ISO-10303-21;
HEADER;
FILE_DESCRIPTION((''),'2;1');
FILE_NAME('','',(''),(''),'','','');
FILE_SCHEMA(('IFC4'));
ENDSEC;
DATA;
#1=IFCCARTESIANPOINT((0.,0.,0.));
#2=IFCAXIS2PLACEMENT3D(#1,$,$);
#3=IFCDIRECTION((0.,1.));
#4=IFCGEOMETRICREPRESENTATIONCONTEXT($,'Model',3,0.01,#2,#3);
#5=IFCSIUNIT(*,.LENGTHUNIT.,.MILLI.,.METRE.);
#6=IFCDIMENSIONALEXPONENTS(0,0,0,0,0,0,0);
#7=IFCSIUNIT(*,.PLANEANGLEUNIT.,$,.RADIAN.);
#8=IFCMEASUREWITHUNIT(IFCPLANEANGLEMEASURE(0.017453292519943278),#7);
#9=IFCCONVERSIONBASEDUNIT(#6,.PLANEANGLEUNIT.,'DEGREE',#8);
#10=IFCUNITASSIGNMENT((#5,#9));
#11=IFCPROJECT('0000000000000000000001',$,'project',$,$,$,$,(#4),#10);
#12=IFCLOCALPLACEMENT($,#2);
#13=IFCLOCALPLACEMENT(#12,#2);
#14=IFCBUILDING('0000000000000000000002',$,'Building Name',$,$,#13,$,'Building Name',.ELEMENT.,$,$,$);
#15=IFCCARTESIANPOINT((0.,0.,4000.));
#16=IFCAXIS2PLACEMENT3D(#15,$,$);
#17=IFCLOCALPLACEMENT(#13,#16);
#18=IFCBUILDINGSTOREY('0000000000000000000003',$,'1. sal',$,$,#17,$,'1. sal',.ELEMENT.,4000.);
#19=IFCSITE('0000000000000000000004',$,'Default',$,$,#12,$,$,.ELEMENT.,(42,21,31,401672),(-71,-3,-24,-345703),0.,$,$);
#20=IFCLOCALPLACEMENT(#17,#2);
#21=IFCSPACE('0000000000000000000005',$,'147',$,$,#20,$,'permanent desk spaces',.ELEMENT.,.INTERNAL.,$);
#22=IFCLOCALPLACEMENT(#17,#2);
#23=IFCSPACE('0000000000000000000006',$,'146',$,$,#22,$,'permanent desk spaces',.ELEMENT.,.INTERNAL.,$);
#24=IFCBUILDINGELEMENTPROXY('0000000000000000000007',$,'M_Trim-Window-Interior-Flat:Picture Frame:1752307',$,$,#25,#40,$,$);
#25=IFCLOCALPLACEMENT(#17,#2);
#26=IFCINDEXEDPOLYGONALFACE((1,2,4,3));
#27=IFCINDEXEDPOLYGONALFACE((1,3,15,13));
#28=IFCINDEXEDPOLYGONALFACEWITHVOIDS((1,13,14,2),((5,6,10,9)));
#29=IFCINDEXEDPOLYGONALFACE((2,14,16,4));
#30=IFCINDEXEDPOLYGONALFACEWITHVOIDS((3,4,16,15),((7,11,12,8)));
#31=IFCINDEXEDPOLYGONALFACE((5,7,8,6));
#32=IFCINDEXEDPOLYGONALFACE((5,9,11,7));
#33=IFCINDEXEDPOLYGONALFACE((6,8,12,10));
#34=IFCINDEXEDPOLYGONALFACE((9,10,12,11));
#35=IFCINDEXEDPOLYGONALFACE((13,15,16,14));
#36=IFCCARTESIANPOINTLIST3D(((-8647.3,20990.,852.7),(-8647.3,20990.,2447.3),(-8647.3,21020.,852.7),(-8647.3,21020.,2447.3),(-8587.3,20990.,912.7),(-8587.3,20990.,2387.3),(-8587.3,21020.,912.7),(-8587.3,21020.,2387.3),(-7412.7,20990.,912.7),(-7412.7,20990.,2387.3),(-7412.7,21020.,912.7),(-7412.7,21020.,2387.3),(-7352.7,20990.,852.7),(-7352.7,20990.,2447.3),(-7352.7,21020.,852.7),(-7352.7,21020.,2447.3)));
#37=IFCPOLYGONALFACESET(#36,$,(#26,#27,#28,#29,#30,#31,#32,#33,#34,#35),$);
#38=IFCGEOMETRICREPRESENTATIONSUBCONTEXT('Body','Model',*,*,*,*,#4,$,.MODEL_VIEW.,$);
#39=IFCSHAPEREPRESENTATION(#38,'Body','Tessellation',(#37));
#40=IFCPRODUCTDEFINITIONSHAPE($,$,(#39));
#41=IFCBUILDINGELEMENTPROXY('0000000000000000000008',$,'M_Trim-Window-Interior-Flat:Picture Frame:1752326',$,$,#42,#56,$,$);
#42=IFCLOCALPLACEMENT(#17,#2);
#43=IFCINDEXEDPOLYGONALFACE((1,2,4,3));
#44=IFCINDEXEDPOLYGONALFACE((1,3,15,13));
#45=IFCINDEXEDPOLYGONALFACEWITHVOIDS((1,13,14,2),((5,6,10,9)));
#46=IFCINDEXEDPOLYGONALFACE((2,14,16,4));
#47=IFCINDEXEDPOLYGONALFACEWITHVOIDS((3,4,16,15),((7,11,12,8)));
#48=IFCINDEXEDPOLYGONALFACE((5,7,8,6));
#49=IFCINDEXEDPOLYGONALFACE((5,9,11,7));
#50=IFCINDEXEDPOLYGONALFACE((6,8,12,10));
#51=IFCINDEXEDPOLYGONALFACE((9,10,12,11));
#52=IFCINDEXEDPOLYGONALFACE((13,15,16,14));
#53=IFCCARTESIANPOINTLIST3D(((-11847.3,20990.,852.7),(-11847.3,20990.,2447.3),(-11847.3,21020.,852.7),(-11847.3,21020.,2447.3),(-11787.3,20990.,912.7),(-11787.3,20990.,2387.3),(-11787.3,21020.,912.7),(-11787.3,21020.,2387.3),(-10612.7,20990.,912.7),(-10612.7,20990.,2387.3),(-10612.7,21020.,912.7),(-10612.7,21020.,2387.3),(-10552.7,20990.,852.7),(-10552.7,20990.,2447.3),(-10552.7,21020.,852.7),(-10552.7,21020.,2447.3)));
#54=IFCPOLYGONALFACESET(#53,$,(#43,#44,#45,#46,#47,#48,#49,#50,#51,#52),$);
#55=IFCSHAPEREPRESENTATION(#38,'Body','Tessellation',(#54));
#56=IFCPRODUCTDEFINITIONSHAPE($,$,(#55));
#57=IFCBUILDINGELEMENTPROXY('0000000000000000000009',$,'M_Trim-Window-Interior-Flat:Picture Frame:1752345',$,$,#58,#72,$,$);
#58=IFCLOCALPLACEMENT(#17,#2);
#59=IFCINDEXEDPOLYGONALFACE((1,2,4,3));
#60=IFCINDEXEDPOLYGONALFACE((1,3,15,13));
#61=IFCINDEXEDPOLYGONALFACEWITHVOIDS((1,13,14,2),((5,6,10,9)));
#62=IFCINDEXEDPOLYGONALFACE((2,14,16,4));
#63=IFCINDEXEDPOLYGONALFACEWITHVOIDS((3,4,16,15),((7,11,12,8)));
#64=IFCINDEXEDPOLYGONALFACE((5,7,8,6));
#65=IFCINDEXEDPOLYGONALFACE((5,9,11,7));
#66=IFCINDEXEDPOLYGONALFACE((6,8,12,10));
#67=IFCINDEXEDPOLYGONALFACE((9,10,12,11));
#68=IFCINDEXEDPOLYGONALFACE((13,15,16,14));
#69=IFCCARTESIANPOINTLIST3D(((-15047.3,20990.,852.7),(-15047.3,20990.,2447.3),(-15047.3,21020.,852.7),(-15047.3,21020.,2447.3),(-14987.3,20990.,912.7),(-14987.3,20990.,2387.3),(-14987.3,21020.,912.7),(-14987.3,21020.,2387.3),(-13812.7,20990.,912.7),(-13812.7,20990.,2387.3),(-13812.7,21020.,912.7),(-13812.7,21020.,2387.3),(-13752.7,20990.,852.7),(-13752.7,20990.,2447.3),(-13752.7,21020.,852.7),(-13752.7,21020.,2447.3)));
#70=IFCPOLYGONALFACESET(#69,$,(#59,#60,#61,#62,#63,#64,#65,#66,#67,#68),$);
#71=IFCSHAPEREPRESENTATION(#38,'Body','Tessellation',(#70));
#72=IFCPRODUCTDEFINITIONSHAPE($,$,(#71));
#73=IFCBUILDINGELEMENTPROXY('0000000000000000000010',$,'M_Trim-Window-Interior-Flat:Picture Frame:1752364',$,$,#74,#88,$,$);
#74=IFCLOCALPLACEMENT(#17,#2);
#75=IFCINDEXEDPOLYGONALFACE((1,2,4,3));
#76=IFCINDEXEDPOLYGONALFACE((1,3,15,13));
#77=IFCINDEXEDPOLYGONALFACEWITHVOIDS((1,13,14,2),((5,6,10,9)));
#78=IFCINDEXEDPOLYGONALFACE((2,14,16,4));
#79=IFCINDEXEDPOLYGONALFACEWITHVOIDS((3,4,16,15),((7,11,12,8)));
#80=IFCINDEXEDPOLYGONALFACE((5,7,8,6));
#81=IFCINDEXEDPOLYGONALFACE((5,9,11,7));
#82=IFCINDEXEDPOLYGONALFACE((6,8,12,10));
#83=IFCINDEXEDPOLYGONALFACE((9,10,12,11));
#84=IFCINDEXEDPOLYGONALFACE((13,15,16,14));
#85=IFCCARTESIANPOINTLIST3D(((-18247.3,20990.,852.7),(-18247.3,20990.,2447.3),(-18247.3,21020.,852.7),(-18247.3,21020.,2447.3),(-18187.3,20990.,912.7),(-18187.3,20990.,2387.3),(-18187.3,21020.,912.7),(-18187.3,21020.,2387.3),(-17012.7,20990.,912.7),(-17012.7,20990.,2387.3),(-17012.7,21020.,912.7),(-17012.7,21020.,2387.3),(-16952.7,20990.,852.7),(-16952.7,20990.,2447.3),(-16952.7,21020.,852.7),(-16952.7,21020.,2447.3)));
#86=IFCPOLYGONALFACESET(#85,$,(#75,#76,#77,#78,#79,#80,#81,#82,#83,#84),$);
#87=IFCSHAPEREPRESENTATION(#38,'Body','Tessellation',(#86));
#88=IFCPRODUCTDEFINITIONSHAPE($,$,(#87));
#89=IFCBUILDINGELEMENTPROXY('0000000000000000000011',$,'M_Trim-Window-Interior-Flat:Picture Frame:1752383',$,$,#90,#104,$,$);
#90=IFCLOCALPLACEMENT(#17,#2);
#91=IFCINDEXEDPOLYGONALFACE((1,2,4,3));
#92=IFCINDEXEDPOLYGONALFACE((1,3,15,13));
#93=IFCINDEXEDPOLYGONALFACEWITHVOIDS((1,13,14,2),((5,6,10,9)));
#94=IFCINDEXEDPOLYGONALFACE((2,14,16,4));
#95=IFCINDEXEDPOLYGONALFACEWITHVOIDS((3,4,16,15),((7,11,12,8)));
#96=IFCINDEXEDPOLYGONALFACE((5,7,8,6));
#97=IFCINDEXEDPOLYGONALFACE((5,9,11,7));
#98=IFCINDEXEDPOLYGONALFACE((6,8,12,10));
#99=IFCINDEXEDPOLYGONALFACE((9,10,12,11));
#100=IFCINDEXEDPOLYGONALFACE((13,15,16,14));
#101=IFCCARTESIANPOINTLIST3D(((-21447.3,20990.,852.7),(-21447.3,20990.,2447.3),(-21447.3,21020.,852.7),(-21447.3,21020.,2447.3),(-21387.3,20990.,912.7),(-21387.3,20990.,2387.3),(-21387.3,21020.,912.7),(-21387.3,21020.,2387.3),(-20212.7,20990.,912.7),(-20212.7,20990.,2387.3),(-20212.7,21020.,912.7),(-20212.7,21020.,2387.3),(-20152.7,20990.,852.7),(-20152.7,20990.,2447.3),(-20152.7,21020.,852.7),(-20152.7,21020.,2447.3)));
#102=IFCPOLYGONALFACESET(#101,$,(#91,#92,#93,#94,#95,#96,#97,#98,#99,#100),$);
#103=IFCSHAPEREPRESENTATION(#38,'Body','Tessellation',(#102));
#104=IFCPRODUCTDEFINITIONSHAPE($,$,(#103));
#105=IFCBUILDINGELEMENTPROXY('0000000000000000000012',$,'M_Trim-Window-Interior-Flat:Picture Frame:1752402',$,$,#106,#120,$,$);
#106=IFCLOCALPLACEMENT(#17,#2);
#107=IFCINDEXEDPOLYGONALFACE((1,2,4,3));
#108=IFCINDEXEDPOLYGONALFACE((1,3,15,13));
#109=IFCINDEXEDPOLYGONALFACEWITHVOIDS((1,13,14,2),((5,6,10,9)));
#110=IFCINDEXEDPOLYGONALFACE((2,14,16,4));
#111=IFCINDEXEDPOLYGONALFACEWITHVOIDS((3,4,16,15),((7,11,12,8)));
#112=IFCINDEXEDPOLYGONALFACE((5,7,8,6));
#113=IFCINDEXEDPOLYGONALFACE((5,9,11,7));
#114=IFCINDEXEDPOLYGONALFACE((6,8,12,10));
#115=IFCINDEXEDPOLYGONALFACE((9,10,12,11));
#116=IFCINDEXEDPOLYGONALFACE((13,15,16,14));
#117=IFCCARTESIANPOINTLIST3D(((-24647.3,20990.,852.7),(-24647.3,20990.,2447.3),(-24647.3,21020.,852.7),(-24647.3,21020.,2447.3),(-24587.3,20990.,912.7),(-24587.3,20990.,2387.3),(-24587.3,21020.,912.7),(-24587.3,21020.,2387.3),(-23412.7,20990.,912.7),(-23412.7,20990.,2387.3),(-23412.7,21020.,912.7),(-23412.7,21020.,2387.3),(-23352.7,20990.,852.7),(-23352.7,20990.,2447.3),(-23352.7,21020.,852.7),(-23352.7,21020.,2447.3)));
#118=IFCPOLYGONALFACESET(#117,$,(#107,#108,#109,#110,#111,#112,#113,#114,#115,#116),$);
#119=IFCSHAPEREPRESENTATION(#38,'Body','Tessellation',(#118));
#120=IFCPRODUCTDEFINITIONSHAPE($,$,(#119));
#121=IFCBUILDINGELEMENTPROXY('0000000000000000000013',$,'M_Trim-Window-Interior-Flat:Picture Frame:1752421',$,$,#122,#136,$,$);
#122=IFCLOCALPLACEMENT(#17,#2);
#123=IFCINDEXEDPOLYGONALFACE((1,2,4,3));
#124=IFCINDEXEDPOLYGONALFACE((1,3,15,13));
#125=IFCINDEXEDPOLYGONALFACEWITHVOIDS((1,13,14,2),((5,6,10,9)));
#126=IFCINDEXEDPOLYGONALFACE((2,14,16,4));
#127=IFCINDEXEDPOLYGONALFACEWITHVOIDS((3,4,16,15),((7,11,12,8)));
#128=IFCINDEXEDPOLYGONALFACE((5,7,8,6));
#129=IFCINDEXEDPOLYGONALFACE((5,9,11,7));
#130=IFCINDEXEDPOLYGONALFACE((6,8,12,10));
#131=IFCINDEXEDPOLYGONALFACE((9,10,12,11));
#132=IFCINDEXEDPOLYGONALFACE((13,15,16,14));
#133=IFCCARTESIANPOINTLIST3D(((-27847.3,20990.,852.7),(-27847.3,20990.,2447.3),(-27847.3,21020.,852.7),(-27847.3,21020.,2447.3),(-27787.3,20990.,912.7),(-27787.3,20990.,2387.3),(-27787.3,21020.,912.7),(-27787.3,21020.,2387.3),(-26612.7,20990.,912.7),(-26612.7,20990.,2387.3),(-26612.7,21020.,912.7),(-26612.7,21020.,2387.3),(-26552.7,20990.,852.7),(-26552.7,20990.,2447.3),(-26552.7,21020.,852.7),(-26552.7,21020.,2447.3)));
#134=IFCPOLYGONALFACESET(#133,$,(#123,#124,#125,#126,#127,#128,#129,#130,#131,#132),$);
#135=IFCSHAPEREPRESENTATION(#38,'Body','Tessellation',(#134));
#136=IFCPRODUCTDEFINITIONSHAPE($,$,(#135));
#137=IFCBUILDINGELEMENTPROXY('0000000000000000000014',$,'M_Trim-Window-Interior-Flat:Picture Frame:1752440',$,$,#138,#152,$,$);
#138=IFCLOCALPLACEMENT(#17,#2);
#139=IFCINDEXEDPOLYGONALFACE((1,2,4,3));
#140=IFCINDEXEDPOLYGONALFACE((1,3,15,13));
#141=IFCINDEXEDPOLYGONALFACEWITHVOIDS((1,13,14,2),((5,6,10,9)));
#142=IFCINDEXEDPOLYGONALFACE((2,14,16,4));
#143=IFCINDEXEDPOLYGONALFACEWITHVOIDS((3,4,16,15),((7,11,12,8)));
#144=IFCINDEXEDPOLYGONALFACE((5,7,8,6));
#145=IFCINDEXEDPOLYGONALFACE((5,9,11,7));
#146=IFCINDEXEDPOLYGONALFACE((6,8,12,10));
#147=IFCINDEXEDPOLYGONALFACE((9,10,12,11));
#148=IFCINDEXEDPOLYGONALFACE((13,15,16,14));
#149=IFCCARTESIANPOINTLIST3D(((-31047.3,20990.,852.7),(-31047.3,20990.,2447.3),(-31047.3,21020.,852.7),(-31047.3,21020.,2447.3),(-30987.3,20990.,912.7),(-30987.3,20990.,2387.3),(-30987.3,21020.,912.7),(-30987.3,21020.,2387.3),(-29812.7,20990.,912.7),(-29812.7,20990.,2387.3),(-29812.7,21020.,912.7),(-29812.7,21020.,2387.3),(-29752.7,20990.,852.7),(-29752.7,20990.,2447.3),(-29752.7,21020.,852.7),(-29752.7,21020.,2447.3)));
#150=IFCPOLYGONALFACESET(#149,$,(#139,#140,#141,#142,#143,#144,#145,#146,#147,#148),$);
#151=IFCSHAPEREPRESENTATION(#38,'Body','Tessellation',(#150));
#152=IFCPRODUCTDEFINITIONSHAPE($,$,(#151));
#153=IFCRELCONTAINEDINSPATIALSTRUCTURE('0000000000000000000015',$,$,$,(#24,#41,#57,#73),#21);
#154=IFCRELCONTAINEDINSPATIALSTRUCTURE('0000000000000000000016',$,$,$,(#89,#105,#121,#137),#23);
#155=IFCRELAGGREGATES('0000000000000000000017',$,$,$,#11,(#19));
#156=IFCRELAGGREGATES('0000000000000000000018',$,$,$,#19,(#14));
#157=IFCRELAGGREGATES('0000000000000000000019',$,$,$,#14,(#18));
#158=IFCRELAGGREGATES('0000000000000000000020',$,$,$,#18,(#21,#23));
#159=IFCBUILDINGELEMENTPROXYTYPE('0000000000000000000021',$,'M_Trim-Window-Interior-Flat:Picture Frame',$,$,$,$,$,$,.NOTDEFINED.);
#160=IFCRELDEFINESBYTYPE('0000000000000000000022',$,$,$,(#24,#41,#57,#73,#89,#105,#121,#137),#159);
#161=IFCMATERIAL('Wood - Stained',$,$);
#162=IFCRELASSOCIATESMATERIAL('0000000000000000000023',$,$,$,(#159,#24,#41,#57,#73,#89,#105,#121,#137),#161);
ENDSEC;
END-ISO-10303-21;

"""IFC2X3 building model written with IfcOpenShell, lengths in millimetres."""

from ifc_helpers import new_model, entity, si_unit, converted_unit, direction, frame, origin, place, context, subcontext, project, spatial, polyline, outline, extrude, source, transform, mapped, material, type_object, type_shapes, element, save


model = new_model("IFC2X3")

# Units and contexts
model_context = context("Model", 3, precision=0.01, world=origin(), true_north=direction((0.0, 1.0)))
body_context = subcontext(model_context, "Body", "Model", "MODEL_VIEW")
ifc_project = project(units=[si_unit("LENGTHUNIT", "METRE", prefix="MILLI"), converted_unit("PLANEANGLEUNIT", "DEGREE", entity("IfcPlaneAngleMeasure", 0.017453292519943278), si_unit("PLANEANGLEUNIT", "RADIAN"), dimensions=[0, 0, 0, 0, 0, 0, 0])], contexts=[model_context])

# Site, building, storey
site_placement = place(None, origin())
site = spatial("IfcSite", under=ifc_project, at=site_placement, Name="Default", CompositionType="ELEMENT", RefLatitude=(42, 21, 31, 401672), RefLongitude=(-71, -3, -24, -345703), RefElevation=0.0)
building_placement = place(site_placement, origin())
building = spatial("IfcBuilding", under=site, at=building_placement, Name="Building Name", LongName="Building Name", CompositionType="ELEMENT")
storey_placement = place(building_placement, frame((0.0, 0.0, 4000.0)))
storey = spatial("IfcBuildingStorey", under=building, at=storey_placement, Name="1. sal", LongName="1. sal", CompositionType="ELEMENT", Elevation=4000.0)

# Shared definitions
space_1_placement = place(storey_placement, origin())
space_1 = spatial("IfcSpace", under=storey, at=space_1_placement, Name="147", LongName="permanent desk spaces", CompositionType="ELEMENT", InteriorOrExteriorSpace="INTERNAL")

# Building element proxies
ifc_material_1 = material(Name="Wood - Stained")
building_element_proxy_type = type_object("IfcBuildingElementProxyType", Name="M_Trim-Window-Interior-Flat:Picture Frame", PredefinedType="NOTDEFINED", material=ifc_material_1)
shared_shape_1 = source(origin(), body_context, "Body", "SweptSolid", [
    extrude(outline(polyline([(-647.3, -797.3), (647.3, -797.3), (647.3, 797.3), (-647.3, 797.3), (-647.3, -797.3)]), holes=[polyline([(-587.3, -737.3), (-587.3, 737.3), (587.3, 737.3), (587.3, -737.3), (-587.3, -737.3)])]), frame((0.0, -750.0, 0.0), z_axis=(0.0, 0.0, 1.0), x_axis=(-1.0, 0.0, 0.0)), (0.0, 0.0, 1.0), 30.0),
])
type_shapes(building_element_proxy_type, [shared_shape_1])
for number, where, z_axis, x_axis, name in (
    (1, (-8000.0, 21020.0, 2400.0), (0.0, -1.0, 0.0), (1.0, 0.0, 0.0), "M_Trim-Window-Interior-Flat:Picture Frame:1752307"),
    (2, (-11200.0, 21020.0, 2400.0), (0.0, -1.0, 0.0), (1.0, 0.0, 0.0), "M_Trim-Window-Interior-Flat:Picture Frame:1752326"),
    (3, (-14400.0, 21020.0, 2400.0), (0.0, -1.0, 0.0), (1.0, 0.0, 0.0), "M_Trim-Window-Interior-Flat:Picture Frame:1752345"),
    (4, (-17600.0, 21020.0, 2400.0), (0.0, -1.0, 0.0), (1.0, 0.0, 0.0), "M_Trim-Window-Interior-Flat:Picture Frame:1752364"),
):
    element("IfcBuildingElementProxy", number, at=place(space_1_placement, frame(where, z_axis=z_axis, x_axis=x_axis)), inside=space_1, type_object=building_element_proxy_type, material=ifc_material_1, Name=name, context=body_context, shape_type="MappedRepresentation", body=[
        mapped(shared_shape_1, transform((0.0, 0.0, 0.0), scale=1.0)),
    ])

# Shared definitions
space_2_placement = place(storey_placement, origin())
space_2 = spatial("IfcSpace", under=storey, at=space_2_placement, Name="146", LongName="permanent desk spaces", CompositionType="ELEMENT", InteriorOrExteriorSpace="INTERNAL")

# Building element proxies
for number, where, z_axis, x_axis, name in (
    (5, (-20800.0, 21020.0, 2400.0), (0.0, -1.0, 0.0), (1.0, 0.0, 0.0), "M_Trim-Window-Interior-Flat:Picture Frame:1752383"),
    (6, (-24000.0, 21020.0, 2400.0), (0.0, -1.0, 0.0), (1.0, 0.0, 0.0), "M_Trim-Window-Interior-Flat:Picture Frame:1752402"),
    (7, (-27200.0, 21020.0, 2400.0), (0.0, -1.0, 0.0), (1.0, 0.0, 0.0), "M_Trim-Window-Interior-Flat:Picture Frame:1752421"),
    (8, (-30400.0, 21020.0, 2400.0), (0.0, -1.0, 0.0), (1.0, 0.0, 0.0), "M_Trim-Window-Interior-Flat:Picture Frame:1752440"),
):
    element("IfcBuildingElementProxy", number, at=place(space_2_placement, frame(where, z_axis=z_axis, x_axis=x_axis)), inside=space_2, type_object=building_element_proxy_type, material=ifc_material_1, Name=name, context=body_context, shape_type="MappedRepresentation", body=[
        mapped(shared_shape_1, transform((0.0, 0.0, 0.0), scale=1.0)),
    ])

save(model, "model.ifc")
